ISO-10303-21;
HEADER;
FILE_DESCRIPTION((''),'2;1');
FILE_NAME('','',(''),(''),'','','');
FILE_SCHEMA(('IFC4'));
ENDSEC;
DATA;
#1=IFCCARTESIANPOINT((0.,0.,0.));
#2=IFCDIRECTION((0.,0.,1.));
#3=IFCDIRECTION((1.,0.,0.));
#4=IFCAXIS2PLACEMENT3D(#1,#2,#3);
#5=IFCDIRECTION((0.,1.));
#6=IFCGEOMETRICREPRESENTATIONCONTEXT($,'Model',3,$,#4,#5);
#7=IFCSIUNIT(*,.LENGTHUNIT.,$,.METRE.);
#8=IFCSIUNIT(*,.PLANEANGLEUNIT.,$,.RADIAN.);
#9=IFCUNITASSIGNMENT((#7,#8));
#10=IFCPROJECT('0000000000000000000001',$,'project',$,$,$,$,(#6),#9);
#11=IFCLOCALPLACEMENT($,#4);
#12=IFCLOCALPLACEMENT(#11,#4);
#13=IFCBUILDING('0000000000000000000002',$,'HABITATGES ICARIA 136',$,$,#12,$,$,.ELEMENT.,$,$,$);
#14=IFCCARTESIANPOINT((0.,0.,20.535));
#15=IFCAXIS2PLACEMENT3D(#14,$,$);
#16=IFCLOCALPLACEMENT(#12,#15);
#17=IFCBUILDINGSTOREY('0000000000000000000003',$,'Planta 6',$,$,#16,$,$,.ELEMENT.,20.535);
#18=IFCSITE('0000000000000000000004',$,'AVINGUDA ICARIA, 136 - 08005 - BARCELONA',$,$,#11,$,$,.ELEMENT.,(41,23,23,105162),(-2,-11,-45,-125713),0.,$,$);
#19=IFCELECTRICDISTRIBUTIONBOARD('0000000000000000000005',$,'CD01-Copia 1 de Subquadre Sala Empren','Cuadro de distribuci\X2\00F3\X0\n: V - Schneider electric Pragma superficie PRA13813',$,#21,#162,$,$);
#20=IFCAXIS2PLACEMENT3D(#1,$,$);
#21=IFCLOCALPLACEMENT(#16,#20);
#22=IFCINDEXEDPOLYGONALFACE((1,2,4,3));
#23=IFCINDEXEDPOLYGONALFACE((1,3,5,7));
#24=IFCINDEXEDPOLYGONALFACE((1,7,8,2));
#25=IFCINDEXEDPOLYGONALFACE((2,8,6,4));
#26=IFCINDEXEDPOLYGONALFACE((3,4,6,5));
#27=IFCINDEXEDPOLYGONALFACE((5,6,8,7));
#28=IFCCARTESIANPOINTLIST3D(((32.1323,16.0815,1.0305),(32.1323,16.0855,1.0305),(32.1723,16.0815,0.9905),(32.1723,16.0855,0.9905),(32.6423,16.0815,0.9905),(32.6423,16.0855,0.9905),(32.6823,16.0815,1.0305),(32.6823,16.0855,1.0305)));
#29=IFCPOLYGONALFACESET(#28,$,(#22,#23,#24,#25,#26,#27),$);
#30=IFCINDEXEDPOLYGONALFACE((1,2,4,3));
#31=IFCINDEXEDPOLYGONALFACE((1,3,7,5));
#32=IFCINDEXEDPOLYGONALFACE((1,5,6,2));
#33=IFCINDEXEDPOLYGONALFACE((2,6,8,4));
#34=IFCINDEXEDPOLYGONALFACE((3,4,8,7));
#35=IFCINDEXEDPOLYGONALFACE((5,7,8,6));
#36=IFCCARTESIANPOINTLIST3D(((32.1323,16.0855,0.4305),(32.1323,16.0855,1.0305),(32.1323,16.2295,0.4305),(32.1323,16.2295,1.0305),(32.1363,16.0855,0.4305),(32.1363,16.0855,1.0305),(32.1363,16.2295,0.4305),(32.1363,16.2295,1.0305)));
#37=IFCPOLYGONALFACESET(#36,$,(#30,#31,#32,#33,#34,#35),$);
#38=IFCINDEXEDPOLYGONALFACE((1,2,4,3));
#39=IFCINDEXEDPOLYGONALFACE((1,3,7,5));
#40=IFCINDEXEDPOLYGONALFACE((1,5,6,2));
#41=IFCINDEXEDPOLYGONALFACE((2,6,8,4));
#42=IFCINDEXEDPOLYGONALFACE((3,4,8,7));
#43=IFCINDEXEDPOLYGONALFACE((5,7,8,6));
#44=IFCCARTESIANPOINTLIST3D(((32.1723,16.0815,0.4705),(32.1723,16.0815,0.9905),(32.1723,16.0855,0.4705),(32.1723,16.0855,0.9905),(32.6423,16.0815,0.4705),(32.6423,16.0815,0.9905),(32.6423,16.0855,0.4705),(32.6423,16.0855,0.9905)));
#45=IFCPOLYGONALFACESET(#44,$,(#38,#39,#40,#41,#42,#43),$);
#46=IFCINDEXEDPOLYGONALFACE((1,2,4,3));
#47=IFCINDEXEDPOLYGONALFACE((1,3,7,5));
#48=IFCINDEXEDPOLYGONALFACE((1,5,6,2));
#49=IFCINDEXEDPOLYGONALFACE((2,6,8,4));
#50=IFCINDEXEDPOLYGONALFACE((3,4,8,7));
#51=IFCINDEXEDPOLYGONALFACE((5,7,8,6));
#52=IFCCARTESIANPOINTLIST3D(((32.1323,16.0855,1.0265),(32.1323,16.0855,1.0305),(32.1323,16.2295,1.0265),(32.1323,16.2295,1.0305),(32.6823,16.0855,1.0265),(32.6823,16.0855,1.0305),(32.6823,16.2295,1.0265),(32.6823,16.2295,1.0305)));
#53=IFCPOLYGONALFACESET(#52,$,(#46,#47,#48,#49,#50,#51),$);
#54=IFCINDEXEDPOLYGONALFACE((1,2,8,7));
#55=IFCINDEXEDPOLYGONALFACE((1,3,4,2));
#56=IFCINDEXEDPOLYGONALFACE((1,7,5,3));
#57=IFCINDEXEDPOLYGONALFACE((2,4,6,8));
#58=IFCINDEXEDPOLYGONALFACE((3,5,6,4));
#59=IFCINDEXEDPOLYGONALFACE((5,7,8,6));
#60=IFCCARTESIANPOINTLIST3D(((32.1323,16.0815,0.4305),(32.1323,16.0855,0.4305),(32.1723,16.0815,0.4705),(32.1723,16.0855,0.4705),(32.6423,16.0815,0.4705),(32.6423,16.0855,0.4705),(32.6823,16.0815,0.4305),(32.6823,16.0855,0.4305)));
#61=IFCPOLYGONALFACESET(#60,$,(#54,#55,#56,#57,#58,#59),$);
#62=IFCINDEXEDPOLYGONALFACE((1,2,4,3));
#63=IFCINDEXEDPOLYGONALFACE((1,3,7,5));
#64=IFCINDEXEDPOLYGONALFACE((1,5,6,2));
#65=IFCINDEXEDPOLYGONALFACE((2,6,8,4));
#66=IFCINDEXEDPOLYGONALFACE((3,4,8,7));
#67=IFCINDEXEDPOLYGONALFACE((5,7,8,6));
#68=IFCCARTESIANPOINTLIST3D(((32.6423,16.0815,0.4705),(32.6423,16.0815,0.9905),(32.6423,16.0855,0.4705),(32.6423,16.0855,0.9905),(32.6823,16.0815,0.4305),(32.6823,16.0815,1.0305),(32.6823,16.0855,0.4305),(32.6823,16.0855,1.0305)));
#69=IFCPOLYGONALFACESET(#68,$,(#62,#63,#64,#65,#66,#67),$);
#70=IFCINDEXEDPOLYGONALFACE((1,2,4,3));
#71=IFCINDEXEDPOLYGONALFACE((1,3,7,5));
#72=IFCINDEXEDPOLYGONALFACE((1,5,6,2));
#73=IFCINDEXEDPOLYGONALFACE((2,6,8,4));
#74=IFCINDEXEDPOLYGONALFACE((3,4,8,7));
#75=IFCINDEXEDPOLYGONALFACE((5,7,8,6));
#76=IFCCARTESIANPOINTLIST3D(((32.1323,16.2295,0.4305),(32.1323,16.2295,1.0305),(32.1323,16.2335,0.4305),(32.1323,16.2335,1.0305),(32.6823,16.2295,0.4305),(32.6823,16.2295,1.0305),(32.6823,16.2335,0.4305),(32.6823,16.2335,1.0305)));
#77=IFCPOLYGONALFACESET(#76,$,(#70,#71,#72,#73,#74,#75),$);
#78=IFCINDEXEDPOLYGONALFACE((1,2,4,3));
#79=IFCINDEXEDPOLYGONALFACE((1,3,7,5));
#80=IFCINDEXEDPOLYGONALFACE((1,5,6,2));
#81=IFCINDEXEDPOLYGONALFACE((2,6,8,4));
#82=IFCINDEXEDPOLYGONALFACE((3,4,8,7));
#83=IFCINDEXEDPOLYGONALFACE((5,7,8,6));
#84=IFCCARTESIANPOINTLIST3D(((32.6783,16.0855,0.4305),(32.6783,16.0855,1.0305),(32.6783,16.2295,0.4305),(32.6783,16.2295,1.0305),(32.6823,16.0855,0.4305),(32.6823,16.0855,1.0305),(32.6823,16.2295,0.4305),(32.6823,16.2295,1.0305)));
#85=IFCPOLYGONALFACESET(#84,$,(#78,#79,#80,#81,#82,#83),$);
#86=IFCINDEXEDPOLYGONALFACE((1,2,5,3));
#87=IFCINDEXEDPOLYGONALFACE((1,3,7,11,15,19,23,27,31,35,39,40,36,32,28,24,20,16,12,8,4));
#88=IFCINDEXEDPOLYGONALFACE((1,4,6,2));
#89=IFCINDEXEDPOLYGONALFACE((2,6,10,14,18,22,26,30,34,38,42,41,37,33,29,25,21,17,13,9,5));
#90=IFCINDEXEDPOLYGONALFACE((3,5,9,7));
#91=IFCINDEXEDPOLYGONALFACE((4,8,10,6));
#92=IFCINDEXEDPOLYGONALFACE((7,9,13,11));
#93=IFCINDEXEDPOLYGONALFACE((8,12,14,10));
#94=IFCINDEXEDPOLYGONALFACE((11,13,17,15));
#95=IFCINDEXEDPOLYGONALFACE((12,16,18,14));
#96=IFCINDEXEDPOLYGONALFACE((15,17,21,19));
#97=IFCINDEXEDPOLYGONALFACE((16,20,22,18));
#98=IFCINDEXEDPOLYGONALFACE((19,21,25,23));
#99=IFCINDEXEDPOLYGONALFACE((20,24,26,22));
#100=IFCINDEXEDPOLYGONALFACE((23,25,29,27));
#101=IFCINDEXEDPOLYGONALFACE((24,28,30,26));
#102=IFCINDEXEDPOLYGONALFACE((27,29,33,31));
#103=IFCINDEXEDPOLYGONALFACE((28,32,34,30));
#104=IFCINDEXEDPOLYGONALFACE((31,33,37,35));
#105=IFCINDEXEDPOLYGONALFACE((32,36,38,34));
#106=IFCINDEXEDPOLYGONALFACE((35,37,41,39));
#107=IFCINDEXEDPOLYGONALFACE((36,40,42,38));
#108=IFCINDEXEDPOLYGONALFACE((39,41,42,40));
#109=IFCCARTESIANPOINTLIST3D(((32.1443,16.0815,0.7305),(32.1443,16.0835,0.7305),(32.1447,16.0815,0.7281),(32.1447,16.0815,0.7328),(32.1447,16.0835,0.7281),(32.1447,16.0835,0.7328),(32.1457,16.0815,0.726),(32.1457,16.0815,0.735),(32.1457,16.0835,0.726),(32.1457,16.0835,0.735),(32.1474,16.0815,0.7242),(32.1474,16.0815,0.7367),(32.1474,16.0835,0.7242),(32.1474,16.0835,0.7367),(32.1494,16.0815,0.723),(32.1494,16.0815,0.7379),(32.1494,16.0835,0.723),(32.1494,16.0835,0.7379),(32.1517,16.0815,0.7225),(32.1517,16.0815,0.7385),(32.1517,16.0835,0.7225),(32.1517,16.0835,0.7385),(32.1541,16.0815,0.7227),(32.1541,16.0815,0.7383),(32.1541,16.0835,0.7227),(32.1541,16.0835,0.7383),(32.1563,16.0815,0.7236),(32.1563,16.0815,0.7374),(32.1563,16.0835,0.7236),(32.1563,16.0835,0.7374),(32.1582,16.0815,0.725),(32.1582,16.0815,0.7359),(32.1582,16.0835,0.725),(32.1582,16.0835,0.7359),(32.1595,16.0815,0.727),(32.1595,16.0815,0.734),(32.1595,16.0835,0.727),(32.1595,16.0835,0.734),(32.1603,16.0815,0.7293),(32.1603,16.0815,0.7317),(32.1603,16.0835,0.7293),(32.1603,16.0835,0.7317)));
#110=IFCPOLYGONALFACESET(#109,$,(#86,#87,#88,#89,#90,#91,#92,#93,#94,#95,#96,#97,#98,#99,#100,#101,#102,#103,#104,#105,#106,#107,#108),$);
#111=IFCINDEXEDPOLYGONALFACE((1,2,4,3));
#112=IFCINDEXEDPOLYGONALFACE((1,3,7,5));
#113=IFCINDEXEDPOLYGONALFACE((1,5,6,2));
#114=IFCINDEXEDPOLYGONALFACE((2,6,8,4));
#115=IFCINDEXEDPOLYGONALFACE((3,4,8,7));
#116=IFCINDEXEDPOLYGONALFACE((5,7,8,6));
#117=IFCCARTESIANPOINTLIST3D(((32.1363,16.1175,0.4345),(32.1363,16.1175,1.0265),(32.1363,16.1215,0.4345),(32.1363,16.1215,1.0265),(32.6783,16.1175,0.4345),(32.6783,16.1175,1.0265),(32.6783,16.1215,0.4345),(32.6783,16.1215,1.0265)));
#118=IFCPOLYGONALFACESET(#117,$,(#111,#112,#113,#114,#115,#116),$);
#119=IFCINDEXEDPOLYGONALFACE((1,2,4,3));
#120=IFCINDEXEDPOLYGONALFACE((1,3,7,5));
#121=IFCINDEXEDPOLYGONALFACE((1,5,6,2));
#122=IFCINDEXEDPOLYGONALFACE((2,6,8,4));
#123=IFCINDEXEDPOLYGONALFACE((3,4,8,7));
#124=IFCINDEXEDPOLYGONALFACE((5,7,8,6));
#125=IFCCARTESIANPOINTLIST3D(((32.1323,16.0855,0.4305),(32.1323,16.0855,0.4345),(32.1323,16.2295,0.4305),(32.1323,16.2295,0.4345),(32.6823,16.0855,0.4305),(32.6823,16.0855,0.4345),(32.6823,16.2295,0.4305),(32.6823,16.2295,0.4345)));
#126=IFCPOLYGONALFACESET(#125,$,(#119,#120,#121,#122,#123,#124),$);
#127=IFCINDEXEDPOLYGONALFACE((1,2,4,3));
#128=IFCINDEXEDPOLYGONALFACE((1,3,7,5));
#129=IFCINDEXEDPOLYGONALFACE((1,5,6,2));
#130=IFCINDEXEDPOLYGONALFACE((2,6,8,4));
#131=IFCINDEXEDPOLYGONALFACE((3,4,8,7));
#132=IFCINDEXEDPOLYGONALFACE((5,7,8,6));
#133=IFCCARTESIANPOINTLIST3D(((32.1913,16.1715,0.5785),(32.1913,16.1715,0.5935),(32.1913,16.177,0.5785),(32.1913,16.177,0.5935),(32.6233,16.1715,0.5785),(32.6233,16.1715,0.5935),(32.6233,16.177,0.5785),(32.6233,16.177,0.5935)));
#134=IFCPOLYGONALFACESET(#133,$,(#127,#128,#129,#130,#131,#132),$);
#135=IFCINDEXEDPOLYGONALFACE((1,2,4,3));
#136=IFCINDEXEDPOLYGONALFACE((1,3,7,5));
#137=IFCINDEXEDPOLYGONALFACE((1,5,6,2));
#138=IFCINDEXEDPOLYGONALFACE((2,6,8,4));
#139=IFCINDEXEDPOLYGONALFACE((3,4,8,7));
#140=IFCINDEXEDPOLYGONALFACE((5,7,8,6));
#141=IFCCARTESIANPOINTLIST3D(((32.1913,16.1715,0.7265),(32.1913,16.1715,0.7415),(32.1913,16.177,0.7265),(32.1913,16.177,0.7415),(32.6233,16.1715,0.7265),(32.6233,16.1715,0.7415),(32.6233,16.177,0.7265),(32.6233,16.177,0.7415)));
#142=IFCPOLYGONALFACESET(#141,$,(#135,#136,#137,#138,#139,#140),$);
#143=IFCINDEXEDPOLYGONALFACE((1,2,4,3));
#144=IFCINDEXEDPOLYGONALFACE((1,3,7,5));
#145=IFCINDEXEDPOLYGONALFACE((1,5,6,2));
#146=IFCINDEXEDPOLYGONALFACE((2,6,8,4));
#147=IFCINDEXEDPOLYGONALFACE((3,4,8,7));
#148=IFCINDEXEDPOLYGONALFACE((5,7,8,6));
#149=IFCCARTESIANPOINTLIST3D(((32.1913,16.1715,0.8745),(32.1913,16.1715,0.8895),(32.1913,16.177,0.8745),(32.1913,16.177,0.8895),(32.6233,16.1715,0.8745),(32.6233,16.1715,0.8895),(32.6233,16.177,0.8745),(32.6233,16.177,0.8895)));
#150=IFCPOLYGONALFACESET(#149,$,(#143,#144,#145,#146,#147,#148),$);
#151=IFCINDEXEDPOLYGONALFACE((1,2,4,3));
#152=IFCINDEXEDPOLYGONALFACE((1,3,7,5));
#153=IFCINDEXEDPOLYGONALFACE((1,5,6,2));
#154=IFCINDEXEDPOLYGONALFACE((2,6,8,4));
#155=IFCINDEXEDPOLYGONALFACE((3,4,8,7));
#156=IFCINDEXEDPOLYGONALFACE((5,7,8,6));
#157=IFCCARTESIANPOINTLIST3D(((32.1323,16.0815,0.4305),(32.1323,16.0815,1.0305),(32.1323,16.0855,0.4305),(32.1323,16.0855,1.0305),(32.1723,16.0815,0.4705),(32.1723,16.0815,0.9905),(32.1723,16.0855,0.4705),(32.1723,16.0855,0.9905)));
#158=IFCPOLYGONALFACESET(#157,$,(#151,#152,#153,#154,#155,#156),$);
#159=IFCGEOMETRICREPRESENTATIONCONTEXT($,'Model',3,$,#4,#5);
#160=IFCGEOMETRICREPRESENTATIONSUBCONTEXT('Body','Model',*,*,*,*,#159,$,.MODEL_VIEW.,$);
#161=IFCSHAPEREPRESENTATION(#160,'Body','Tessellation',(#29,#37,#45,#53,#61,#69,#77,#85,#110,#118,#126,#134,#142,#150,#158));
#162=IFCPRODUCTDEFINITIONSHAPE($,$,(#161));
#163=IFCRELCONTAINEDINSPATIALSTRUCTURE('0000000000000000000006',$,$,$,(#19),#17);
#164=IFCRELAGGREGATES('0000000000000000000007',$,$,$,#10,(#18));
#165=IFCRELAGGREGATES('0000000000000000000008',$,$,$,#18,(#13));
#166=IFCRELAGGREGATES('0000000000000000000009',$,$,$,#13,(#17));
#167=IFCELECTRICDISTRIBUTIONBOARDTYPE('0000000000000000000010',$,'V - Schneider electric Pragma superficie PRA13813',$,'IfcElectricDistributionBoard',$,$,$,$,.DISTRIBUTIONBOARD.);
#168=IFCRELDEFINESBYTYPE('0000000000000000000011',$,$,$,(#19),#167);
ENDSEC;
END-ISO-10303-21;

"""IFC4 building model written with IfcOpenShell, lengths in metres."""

from ifc_helpers import new_model, si_unit, direction, frame, origin_with_axes, origin_2d_with_axis, place, context, subcontext, project, spatial, polyline, circle, outline, extrude, source, transform, mapped, type_object, element, save


model = new_model("IFC4")

# Units and contexts
model_context_1 = context("Model", 3, world=origin_with_axes(), true_north=direction((0.0, 1.0)))
model_context_2 = context("Model", 3, world=origin_with_axes(), true_north=direction((0.0, 1.0)))
body_context_1 = subcontext(model_context_2, "Body", "Model", "MODEL_VIEW")
ifc_project = project(units=[si_unit("LENGTHUNIT", "METRE"), si_unit("PLANEANGLEUNIT", "RADIAN")], contexts=[model_context_1])

# Site, building, storey
site_placement = place(None, origin_with_axes())
site = spatial("IfcSite", under=ifc_project, at=site_placement, Name="AVINGUDA ICARIA, 136 - 08005 - BARCELONA", CompositionType="ELEMENT", RefLatitude=(41, 23, 23, 105162), RefLongitude=(-2, -11, -45, -125713), RefElevation=0.0)
building_placement = place(site_placement, origin_with_axes())
building = spatial("IfcBuilding", under=site, at=building_placement, Name="HABITATGES ICARIA 136", CompositionType="ELEMENT")
storey_placement = place(building_placement, frame((0.0, 0.0, 20.535)))
storey = spatial("IfcBuildingStorey", under=building, at=storey_placement, Name="Planta 6", CompositionType="ELEMENT", Elevation=20.535)

# Shared definitions
placement_1 = place(None, origin_with_axes())
placement_2 = place(placement_1, origin_with_axes())
placement_3 = place(placement_2, frame((0.0, 0.0, 20.535)))

# Electric distribution board
electric_distribution_board_type = type_object("IfcElectricDistributionBoardType", Name="V - Schneider electric Pragma superficie PRA13813", ApplicableOccurrence="IfcElectricDistributionBoard", PredefinedType="DISTRIBUTIONBOARD")
shared_shape = source(origin_with_axes(), body_context_1, "Body", "SweptSolid", [
    extrude(outline(polyline([(-0.275, 0.6), (0.275, 0.6), (0.235, 0.56), (-0.235, 0.56), (-0.275, 0.6)])), frame((0.0, -0.152, 0.0), z_axis=(0.0, 1.0, 0.0), x_axis=(-1.0, 0.0, 0.0)), (0.0, 0.0, 1.0), 0.004),
    extrude(outline(polyline([(-0.275, -0.004), (-0.271, -0.004), (-0.271, -0.148), (-0.275, -0.148), (-0.275, -0.004)])), origin_with_axes(), (0.0, 0.0, 1.0), 0.6),
    extrude(outline(polyline([(-0.235, -0.152), (0.235, -0.152), (0.235, -0.148), (-0.235, -0.148), (-0.235, -0.152)])), frame((0.0, 0.0, 0.04), z_axis=(0.0, 0.0, 1.0), x_axis=(1.0, 0.0, 0.0)), (0.0, 0.0, 1.0), 0.52),
    extrude(outline(polyline([(-0.275, -0.004), (0.275, -0.004), (0.275, -0.148), (-0.275, -0.148), (-0.275, -0.004)])), frame((0.0, 0.0, 0.596), z_axis=(0.0, 0.0, 1.0), x_axis=(1.0, 0.0, 0.0)), (0.0, 0.0, 1.0), 0.004),
    extrude(outline(polyline([(-0.275, 0.0), (0.275, 0.0), (0.235, 0.04), (-0.235, 0.04), (-0.275, 0.0)])), frame((0.0, -0.152, 0.0), z_axis=(0.0, 1.0, 0.0), x_axis=(-1.0, 0.0, 0.0)), (0.0, 0.0, 1.0), 0.004),
    extrude(outline(polyline([(-0.275, 0.0), (-0.235, 0.04), (-0.235, 0.56), (-0.275, 0.6), (-0.275, 0.0)])), frame((0.0, -0.152, 0.0), z_axis=(0.0, 1.0, 0.0), x_axis=(-1.0, 0.0, 0.0)), (0.0, 0.0, 1.0), 0.004),
    extrude(outline(polyline([(-0.275, 0.0), (0.275, 0.0), (0.275, -0.004), (-0.275, -0.004), (-0.275, 0.0)])), origin_with_axes(), (0.0, 0.0, 1.0), 0.6),
    extrude(outline(polyline([(0.271, -0.004), (0.275, -0.004), (0.275, -0.148), (0.271, -0.148), (0.271, -0.004)])), origin_with_axes(), (0.0, 0.0, 1.0), 0.6),
    extrude(circle(Radius=0.008, at=origin_2d_with_axis()), frame((-0.255, -0.152, 0.3), z_axis=(0.0, 1.0, 0.0), x_axis=(-1.0, 0.0, 0.0)), (0.0, 0.0, 1.0), 0.002),
    extrude(outline(polyline([(-0.271, -0.116), (0.271, -0.116), (0.271, -0.112), (-0.271, -0.112), (-0.271, -0.116)])), frame((0.0, 0.0, 0.004), z_axis=(0.0, 0.0, 1.0), x_axis=(1.0, 0.0, 0.0)), (0.0, 0.0, 1.0), 0.592),
    extrude(outline(polyline([(-0.275, -0.004), (0.275, -0.004), (0.275, -0.148), (-0.275, -0.148), (-0.275, -0.004)])), origin_with_axes(), (0.0, 0.0, 1.0), 0.004),
    extrude(outline(polyline([(-0.216, -0.062), (0.216, -0.062), (0.216, -0.0565), (-0.216, -0.0565), (-0.216, -0.062)])), frame((0.0, 0.0, 0.148), z_axis=(0.0, 0.0, 1.0), x_axis=(1.0, 0.0, 0.0)), (0.0, 0.0, 1.0), 0.015),
    extrude(outline(polyline([(-0.216, -0.062), (0.216, -0.062), (0.216, -0.0565), (-0.216, -0.0565), (-0.216, -0.062)])), frame((0.0, 0.0, 0.296), z_axis=(0.0, 0.0, 1.0), x_axis=(1.0, 0.0, 0.0)), (0.0, 0.0, 1.0), 0.015),
    extrude(outline(polyline([(-0.216, -0.062), (0.216, -0.062), (0.216, -0.0565), (-0.216, -0.0565), (-0.216, -0.062)])), frame((0.0, 0.0, 0.444), z_axis=(0.0, 0.0, 1.0), x_axis=(1.0, 0.0, 0.0)), (0.0, 0.0, 1.0), 0.015),
    extrude(outline(polyline([(0.275, 0.0), (0.235, 0.04), (0.235, 0.56), (0.275, 0.6), (0.275, 0.0)])), frame((0.0, -0.152, 0.0), z_axis=(0.0, 1.0, 0.0), x_axis=(-1.0, 0.0, 0.0)), (0.0, 0.0, 1.0), 0.004),
])
electric_distribution_board_placement = place(placement_3, origin_with_axes())
element("IfcElectricDistributionBoard", 1, at=electric_distribution_board_placement, inside=storey, type_object=electric_distribution_board_type, Name="CD01-Copia 1 de Subquadre Sala Empren", Description="Cuadro de distribución: V - Schneider electric Pragma superficie PRA13813", context=body_context_1, shape_type="MappedRepresentation", body=[
    mapped(shared_shape, transform((32.4073, 16.2335, 0.4305), x_axis=(1.0, 0.0, 0.0), y_axis=(0.0, 1.0, 0.0), z_axis=(0.0, 0.0, 1.0), scale=1.0)),
])

save(model, "model.ifc")
